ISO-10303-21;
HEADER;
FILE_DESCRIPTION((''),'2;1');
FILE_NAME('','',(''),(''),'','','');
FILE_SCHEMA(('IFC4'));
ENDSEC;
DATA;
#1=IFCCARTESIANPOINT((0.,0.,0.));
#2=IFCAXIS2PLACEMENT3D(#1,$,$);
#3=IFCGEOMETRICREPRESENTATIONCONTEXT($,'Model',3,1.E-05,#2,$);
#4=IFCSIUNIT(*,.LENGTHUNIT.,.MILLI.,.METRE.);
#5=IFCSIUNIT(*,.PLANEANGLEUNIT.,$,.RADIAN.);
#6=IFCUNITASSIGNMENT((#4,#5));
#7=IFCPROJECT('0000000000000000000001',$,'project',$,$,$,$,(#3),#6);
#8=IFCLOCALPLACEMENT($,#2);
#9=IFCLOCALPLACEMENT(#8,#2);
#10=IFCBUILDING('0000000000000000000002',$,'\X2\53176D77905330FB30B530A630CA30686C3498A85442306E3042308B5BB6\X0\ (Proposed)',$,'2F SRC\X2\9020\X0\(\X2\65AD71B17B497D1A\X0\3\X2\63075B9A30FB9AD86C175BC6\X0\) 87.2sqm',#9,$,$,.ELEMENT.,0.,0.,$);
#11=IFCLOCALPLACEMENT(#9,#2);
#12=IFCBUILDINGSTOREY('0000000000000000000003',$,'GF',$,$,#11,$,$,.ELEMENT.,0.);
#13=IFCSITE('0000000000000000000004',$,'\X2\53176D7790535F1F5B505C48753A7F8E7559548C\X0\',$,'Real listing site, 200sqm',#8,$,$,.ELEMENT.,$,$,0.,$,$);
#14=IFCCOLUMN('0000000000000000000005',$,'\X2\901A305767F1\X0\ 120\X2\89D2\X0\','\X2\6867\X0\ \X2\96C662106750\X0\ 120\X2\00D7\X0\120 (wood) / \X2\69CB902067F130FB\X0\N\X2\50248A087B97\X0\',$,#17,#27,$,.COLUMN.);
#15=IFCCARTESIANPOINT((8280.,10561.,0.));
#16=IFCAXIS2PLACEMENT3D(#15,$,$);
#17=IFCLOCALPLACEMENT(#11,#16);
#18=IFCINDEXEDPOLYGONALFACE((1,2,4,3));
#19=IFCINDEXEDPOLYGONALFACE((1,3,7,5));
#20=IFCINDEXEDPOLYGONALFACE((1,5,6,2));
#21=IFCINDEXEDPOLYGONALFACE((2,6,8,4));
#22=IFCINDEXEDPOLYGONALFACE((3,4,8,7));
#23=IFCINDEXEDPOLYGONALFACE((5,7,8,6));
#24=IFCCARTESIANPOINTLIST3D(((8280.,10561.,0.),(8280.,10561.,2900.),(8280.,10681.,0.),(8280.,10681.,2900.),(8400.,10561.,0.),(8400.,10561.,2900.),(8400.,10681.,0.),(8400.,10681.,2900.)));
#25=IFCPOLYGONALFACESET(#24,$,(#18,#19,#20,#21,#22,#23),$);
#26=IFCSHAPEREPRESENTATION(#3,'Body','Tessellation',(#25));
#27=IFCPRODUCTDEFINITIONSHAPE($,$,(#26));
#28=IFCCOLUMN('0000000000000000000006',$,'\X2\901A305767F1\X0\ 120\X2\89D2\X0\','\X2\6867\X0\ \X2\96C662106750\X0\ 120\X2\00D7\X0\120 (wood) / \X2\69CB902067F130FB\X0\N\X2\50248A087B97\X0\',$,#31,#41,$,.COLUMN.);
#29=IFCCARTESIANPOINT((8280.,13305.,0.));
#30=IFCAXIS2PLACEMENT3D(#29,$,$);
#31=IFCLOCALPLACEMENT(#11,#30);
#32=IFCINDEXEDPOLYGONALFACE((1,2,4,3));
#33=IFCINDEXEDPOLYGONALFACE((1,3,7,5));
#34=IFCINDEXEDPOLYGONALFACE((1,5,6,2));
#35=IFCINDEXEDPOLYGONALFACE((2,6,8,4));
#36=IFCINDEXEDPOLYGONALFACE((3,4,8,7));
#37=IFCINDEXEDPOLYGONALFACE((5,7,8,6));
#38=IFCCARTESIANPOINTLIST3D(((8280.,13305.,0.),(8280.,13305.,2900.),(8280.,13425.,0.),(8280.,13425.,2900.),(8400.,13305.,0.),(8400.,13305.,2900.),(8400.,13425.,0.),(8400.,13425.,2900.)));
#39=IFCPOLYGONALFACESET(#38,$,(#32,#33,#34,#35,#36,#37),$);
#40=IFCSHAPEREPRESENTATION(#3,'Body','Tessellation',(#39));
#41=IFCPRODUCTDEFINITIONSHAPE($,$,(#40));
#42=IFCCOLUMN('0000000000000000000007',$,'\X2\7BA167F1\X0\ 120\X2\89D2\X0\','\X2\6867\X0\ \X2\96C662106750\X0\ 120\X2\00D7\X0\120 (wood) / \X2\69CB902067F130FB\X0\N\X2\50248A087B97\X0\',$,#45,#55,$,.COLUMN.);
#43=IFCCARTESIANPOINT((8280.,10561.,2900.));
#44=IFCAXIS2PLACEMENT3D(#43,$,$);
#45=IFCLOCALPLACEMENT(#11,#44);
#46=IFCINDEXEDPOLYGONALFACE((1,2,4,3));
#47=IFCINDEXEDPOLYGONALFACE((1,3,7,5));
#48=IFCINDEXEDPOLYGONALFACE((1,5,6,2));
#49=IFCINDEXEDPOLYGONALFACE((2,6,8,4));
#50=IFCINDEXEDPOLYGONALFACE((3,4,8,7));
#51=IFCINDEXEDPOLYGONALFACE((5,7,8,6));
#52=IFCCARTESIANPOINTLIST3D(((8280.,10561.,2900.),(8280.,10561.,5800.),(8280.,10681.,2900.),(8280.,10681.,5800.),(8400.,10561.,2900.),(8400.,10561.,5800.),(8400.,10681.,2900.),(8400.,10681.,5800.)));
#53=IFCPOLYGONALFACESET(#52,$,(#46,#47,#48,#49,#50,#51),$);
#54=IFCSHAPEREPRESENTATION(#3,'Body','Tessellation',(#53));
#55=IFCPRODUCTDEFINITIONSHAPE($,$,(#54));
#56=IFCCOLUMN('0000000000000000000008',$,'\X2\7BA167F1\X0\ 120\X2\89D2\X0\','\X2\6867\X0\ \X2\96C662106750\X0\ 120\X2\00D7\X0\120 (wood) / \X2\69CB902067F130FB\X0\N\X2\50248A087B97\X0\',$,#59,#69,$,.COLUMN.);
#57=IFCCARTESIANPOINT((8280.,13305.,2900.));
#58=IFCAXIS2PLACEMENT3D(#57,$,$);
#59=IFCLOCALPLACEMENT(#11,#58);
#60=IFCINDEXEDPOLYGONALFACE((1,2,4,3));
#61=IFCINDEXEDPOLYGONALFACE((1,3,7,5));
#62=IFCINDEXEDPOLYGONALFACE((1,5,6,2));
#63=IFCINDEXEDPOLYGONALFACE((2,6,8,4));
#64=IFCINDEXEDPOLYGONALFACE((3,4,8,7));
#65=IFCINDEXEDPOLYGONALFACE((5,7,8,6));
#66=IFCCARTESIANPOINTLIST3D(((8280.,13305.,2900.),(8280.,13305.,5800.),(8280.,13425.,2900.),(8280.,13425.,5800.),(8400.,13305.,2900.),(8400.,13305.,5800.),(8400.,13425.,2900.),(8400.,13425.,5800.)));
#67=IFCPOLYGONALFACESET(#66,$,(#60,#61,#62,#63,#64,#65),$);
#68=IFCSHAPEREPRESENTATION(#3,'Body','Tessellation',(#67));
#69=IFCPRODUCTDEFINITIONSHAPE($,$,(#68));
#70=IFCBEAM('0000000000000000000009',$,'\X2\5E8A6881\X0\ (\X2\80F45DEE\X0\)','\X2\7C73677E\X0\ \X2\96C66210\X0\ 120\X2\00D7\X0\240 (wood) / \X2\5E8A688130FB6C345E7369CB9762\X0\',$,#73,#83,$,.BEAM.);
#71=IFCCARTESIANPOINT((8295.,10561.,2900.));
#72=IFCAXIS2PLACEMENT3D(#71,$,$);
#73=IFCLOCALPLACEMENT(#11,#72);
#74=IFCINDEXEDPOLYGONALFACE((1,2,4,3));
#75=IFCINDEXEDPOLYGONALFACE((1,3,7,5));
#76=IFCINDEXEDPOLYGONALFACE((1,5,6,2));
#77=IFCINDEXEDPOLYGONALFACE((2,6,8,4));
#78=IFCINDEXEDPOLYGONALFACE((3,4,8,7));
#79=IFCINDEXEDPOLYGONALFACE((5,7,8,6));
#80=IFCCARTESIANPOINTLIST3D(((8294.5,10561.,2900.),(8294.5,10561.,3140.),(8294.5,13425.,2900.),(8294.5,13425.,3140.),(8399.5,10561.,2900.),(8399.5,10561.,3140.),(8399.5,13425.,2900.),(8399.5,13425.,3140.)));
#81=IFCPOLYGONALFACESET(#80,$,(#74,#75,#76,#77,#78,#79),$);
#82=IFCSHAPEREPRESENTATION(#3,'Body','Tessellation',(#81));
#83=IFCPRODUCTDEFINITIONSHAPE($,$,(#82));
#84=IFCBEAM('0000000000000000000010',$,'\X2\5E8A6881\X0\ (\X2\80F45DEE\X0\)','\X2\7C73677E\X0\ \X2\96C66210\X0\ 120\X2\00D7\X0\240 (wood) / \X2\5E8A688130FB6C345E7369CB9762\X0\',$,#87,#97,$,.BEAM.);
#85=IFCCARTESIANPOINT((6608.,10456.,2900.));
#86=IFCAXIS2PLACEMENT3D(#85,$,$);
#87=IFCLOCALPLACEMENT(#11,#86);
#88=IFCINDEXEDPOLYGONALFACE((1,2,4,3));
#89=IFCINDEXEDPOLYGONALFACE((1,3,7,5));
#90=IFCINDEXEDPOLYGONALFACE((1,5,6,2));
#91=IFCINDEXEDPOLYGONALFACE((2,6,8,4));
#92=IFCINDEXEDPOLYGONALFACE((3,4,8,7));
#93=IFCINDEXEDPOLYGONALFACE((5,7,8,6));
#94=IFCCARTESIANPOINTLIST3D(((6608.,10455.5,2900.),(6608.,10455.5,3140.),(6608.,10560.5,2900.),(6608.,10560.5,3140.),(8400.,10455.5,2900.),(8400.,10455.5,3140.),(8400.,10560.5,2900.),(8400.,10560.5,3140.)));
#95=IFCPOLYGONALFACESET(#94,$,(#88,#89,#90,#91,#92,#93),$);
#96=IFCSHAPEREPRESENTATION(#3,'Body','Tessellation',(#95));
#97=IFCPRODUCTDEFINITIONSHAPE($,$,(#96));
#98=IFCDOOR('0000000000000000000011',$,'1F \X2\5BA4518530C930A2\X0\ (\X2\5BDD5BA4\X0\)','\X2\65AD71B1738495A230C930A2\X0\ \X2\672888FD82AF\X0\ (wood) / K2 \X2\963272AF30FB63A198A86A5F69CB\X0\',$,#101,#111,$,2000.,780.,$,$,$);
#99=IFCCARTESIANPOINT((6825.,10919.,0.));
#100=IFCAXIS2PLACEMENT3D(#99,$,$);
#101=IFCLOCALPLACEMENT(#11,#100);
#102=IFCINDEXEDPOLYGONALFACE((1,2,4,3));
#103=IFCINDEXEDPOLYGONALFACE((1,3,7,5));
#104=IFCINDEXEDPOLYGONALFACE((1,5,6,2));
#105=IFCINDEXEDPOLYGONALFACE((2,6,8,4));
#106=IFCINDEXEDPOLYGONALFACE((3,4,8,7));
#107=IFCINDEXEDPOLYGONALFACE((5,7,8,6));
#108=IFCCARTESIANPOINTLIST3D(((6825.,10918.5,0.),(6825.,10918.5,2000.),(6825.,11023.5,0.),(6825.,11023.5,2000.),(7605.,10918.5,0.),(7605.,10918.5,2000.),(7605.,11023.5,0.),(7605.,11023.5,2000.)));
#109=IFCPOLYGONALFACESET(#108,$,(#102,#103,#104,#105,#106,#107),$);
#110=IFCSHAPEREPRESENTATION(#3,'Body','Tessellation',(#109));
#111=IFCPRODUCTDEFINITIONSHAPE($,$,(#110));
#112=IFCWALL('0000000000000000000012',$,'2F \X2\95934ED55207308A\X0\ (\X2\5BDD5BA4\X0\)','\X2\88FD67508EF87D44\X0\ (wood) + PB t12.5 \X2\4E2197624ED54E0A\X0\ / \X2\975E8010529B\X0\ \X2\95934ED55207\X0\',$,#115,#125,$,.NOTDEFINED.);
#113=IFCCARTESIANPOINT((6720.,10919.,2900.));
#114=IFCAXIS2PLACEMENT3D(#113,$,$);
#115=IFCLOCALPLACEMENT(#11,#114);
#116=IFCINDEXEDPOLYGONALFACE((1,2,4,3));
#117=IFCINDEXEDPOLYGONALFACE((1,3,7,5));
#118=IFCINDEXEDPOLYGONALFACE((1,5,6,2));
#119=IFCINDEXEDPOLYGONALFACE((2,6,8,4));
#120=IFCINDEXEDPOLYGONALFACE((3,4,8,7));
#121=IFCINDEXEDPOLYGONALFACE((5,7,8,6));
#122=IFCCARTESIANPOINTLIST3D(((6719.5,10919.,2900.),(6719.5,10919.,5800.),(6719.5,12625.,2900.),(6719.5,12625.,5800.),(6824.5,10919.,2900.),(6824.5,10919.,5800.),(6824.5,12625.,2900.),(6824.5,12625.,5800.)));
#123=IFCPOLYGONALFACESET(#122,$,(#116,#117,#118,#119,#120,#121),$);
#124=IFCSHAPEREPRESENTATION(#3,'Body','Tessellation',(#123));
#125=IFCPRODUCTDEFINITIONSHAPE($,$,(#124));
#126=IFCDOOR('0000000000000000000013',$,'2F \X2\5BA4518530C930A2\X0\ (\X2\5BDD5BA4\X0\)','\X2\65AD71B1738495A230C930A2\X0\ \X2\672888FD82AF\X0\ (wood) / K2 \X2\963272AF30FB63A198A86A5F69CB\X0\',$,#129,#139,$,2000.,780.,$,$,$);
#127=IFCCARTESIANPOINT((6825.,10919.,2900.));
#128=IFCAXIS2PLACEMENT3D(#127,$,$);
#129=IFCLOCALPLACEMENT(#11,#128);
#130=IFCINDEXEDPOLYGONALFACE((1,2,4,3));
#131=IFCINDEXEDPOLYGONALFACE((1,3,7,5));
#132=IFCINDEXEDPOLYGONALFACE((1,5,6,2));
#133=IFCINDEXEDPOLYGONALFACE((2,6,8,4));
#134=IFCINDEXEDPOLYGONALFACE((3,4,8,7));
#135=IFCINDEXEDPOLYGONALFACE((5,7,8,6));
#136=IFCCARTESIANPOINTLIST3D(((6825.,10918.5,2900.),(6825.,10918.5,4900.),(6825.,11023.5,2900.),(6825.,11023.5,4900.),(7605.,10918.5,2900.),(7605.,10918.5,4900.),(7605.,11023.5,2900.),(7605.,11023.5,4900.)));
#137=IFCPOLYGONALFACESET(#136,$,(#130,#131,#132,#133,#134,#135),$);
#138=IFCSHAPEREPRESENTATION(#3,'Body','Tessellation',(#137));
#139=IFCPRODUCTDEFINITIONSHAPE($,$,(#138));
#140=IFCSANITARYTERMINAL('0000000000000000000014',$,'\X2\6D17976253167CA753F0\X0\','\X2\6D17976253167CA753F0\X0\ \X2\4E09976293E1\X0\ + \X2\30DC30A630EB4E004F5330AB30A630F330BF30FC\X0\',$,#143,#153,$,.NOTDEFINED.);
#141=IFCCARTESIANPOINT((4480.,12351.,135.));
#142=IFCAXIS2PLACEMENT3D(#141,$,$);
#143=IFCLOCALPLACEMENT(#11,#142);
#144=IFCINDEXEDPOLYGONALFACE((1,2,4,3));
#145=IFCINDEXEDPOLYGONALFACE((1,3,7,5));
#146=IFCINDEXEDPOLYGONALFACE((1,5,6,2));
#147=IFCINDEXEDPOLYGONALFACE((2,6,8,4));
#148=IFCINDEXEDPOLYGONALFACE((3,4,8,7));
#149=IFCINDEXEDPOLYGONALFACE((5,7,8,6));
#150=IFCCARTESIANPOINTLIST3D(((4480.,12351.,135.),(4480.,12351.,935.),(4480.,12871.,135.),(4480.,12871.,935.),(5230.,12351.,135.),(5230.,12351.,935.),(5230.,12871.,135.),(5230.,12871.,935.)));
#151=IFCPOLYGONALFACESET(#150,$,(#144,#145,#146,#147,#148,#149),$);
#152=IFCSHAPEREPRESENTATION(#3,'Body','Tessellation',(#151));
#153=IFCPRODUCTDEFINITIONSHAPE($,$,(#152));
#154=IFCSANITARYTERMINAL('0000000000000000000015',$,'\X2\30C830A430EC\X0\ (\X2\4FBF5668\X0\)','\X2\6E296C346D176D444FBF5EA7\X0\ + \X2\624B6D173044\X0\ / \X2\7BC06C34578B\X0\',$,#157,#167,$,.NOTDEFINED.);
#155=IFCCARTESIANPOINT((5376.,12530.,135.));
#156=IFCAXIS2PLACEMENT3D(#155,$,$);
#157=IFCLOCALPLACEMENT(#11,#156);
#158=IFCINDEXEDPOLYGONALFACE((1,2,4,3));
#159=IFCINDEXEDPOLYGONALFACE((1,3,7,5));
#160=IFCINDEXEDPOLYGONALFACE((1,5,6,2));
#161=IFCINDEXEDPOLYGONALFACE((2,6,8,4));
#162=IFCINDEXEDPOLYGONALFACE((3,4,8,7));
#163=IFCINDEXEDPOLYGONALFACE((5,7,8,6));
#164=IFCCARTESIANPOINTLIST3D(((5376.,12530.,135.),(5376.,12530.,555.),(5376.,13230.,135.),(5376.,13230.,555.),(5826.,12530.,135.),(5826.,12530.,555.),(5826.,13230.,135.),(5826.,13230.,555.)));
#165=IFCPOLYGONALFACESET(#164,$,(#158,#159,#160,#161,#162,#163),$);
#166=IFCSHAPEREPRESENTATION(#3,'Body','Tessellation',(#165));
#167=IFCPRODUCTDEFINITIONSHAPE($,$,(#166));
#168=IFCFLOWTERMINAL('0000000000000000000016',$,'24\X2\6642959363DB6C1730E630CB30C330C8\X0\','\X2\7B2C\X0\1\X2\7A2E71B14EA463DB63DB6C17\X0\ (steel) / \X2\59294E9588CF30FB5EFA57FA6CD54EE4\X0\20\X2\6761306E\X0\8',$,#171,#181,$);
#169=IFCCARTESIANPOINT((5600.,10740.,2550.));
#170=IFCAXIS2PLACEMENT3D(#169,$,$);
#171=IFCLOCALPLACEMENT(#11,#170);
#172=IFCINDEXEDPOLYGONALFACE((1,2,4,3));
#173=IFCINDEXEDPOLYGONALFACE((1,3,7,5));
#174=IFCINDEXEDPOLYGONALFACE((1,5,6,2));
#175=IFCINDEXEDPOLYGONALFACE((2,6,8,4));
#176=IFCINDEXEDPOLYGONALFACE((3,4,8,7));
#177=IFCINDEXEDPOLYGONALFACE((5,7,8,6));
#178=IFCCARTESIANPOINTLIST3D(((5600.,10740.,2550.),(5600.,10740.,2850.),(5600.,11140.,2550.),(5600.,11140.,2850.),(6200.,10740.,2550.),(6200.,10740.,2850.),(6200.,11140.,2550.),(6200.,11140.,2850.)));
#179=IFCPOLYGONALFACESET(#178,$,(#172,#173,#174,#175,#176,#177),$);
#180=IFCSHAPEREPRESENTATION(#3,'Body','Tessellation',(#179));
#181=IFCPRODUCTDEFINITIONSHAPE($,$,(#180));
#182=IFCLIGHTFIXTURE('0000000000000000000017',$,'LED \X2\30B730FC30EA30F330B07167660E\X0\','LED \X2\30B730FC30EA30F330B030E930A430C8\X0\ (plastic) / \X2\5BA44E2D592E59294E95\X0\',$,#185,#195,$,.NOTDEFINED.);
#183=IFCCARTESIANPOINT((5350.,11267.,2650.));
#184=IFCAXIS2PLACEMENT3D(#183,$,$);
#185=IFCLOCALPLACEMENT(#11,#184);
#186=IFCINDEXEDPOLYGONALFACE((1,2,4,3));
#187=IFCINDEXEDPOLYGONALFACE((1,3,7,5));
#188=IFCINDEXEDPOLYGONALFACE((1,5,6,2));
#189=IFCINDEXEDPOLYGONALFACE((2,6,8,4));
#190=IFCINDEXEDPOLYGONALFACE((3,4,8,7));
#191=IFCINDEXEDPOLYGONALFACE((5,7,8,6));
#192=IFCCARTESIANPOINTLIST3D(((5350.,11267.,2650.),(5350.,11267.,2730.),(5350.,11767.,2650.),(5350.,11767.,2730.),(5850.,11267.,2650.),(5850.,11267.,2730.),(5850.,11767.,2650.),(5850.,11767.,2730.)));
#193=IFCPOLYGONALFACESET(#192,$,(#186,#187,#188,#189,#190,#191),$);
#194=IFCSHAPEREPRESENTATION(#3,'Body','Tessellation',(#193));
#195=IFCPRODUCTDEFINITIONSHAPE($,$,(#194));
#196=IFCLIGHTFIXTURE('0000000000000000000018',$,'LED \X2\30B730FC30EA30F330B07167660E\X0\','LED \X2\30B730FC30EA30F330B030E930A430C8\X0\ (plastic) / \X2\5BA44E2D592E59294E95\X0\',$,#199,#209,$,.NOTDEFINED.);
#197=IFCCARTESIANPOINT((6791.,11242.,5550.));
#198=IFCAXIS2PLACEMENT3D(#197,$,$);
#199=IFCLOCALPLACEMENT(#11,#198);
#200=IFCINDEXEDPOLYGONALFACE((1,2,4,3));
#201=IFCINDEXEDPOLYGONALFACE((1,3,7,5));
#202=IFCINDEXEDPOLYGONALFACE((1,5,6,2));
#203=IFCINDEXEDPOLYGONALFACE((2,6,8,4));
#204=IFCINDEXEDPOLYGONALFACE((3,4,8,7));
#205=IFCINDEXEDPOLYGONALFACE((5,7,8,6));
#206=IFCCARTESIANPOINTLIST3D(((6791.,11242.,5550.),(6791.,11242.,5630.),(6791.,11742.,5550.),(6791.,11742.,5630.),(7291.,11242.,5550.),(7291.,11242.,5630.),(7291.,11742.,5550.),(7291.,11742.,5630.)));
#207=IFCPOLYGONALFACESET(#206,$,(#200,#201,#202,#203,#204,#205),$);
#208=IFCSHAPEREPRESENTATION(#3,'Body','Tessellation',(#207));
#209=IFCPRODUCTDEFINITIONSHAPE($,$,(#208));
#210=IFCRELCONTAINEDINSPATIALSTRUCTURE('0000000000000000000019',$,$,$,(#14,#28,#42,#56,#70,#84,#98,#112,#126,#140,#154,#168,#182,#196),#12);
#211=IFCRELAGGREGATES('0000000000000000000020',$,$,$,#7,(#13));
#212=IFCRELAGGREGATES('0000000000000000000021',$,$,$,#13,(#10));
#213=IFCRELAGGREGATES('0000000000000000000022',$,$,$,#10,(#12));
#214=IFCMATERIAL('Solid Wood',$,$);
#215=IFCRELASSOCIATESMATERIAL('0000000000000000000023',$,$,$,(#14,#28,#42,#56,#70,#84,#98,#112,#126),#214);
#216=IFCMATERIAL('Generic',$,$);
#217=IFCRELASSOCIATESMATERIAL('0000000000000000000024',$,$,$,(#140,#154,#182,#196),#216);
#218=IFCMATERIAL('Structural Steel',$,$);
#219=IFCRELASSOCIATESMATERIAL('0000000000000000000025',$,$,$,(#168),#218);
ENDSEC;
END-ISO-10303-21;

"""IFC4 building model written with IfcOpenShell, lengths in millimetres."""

from ifc_helpers import new_model, si_unit, frame, frame_2d, origin, place, context, project, spatial, rectangle, extrude, material, element, save


model = new_model("IFC4")

# Units and contexts
model_context = context("Model", 3, precision=1e-05, world=origin())
ifc_project = project(units=[si_unit("LENGTHUNIT", "METRE", prefix="MILLI"), si_unit("PLANEANGLEUNIT", "RADIAN")], contexts=[model_context])

# Site, building, storey
site_placement = place(None, origin())
site = spatial("IfcSite", under=ifc_project, at=site_placement, Name="北海道弟子屈町美留和", ObjectType="Real listing site, 200sqm", CompositionType="ELEMENT", RefElevation=0.0)
building_placement = place(site_placement, origin())
building = spatial("IfcBuilding", under=site, at=building_placement, Name="北海道・サウナと水風呂のある家 (Proposed)", ObjectType="2F SRC造(断熱等級3指定・高気密) 87.2sqm", CompositionType="ELEMENT", ElevationOfRefHeight=0.0, ElevationOfTerrain=0.0)
storey_placement = place(building_placement, origin())
storey = spatial("IfcBuildingStorey", under=building, at=storey_placement, Name="GF", CompositionType="ELEMENT", Elevation=0.0)

# Columns
ifc_material_1 = material(Name="Solid Wood")
column_1_placement = place(storey_placement, frame((8280.0, 10561.0, 0.0)))
element("IfcColumn", 1, at=column_1_placement, inside=storey, material=ifc_material_1, Name="通し柱 120角", Description="桧 集成材 120×120 (wood) / 構造柱・N値計算", PredefinedType="COLUMN", context=model_context, shape_type="SweptSolid", body=[
    extrude(rectangle(XDim=120.0, YDim=120.0, at=frame_2d((60.0, 60.0))), frame((8280.0, 10561.0, 0.0)), (0.0, 0.0, 1.0), 2900.0),
])
column_2_placement = place(storey_placement, frame((8280.0, 13305.0, 0.0)))
element("IfcColumn", 2, at=column_2_placement, inside=storey, material=ifc_material_1, Name="通し柱 120角", Description="桧 集成材 120×120 (wood) / 構造柱・N値計算", PredefinedType="COLUMN", context=model_context, shape_type="SweptSolid", body=[
    extrude(rectangle(XDim=120.0, YDim=120.0, at=frame_2d((60.0, 60.0))), frame((8280.0, 13305.0, 0.0)), (0.0, 0.0, 1.0), 2900.0),
])
column_3_placement = place(storey_placement, frame((8280.0, 10561.0, 2900.0)))
element("IfcColumn", 3, at=column_3_placement, inside=storey, material=ifc_material_1, Name="管柱 120角", Description="桧 集成材 120×120 (wood) / 構造柱・N値計算", PredefinedType="COLUMN", context=model_context, shape_type="SweptSolid", body=[
    extrude(rectangle(XDim=120.0, YDim=120.0, at=frame_2d((60.0, 60.0))), frame((8280.0, 10561.0, 2900.0)), (0.0, 0.0, 1.0), 2900.0),
])
column_4_placement = place(storey_placement, frame((8280.0, 13305.0, 2900.0)))
element("IfcColumn", 4, at=column_4_placement, inside=storey, material=ifc_material_1, Name="管柱 120角", Description="桧 集成材 120×120 (wood) / 構造柱・N値計算", PredefinedType="COLUMN", context=model_context, shape_type="SweptSolid", body=[
    extrude(rectangle(XDim=120.0, YDim=120.0, at=frame_2d((60.0, 60.0))), frame((8280.0, 13305.0, 2900.0)), (0.0, 0.0, 1.0), 2900.0),
])

# Beams
beam_1_placement = place(storey_placement, frame((8295.0, 10561.0, 2900.0)))
element("IfcBeam", 5, at=beam_1_placement, inside=storey, material=ifc_material_1, Name="床梁 (胴差)", Description="米松 集成 120×240 (wood) / 床梁・水平構面", PredefinedType="BEAM", context=model_context, shape_type="SweptSolid", body=[
    extrude(rectangle(XDim=105.0, YDim=2864.0, at=frame_2d((52.0, 1432.0))), frame((8295.0, 10561.0, 2900.0)), (0.0, 0.0, 1.0), 240.0),
])
beam_2_placement = place(storey_placement, frame((6608.0, 10456.0, 2900.0)))
element("IfcBeam", 6, at=beam_2_placement, inside=storey, material=ifc_material_1, Name="床梁 (胴差)", Description="米松 集成 120×240 (wood) / 床梁・水平構面", PredefinedType="BEAM", context=model_context, shape_type="SweptSolid", body=[
    extrude(rectangle(XDim=1792.0, YDim=105.0, at=frame_2d((896.0, 52.0))), frame((6608.0, 10456.0, 2900.0)), (0.0, 0.0, 1.0), 240.0),
])

# Door
door_1_placement = place(storey_placement, frame((6825.0, 10919.0, 0.0)))
element("IfcDoor", 7, at=door_1_placement, inside=storey, material=ifc_material_1, Name="1F 室内ドア (寝室)", Description="断熱玄関ドア 木製芯 (wood) / K2 防犯・採風機構", OverallHeight=2000.0, OverallWidth=780.0, context=model_context, shape_type="SweptSolid", body=[
    extrude(rectangle(XDim=780.0, YDim=105.0, at=frame_2d((390.0, 52.0))), frame((6825.0, 10919.0, 0.0)), (0.0, 0.0, 1.0), 2000.0),
])

# Wall
wall_1_placement = place(storey_placement, frame((6720.0, 10919.0, 2900.0)))
element("IfcWall", 8, at=wall_1_placement, inside=storey, material=ifc_material_1, Name="2F 間仕切り (寝室)", Description="製材軸組 (wood) + PB t12.5 両面仕上 / 非耐力 間仕切", PredefinedType="NOTDEFINED", context=model_context, shape_type="SweptSolid", body=[
    extrude(rectangle(XDim=105.0, YDim=1706.0, at=frame_2d((52.0, 853.0))), frame((6720.0, 10919.0, 2900.0)), (0.0, 0.0, 1.0), 2900.0),
])

# Door
door_2_placement = place(storey_placement, frame((6825.0, 10919.0, 2900.0)))
element("IfcDoor", 9, at=door_2_placement, inside=storey, material=ifc_material_1, Name="2F 室内ドア (寝室)", Description="断熱玄関ドア 木製芯 (wood) / K2 防犯・採風機構", OverallHeight=2000.0, OverallWidth=780.0, context=model_context, shape_type="SweptSolid", body=[
    extrude(rectangle(XDim=780.0, YDim=105.0, at=frame_2d((390.0, 52.0))), frame((6825.0, 10919.0, 2900.0)), (0.0, 0.0, 1.0), 2000.0),
])

# Sanitary terminals
ifc_material_2 = material(Name="Generic")
sanitary_terminal_1_placement = place(storey_placement, frame((4480.0, 12351.0, 135.0)))
element("IfcSanitaryTerminal", 10, at=sanitary_terminal_1_placement, inside=storey, material=ifc_material_2, Name="洗面化粧台", Description="洗面化粧台 三面鏡 + ボウル一体カウンター", PredefinedType="NOTDEFINED", context=model_context, shape_type="SweptSolid", body=[
    extrude(rectangle(XDim=750.0, YDim=520.0, at=frame_2d((375.0, 260.0))), frame((4480.0, 12351.0, 135.0)), (0.0, 0.0, 1.0), 800.0),
])
sanitary_terminal_2_placement = place(storey_placement, frame((5376.0, 12530.0, 135.0)))
element("IfcSanitaryTerminal", 11, at=sanitary_terminal_2_placement, inside=storey, material=ifc_material_2, Name="トイレ (便器)", Description="温水洗浄便座 + 手洗い / 節水型", PredefinedType="NOTDEFINED", context=model_context, shape_type="SweptSolid", body=[
    extrude(rectangle(XDim=450.0, YDim=700.0, at=frame_2d((225.0, 350.0))), frame((5376.0, 12530.0, 135.0)), (0.0, 0.0, 1.0), 420.0),
])

# Flow terminal
ifc_material_3 = material(Name="Structural Steel")
flow_terminal_placement = place(storey_placement, frame((5600.0, 10740.0, 2550.0)))
element("IfcFlowTerminal", 12, at=flow_terminal_placement, inside=storey, material=ifc_material_3, Name="24時間換気ユニット", Description="第1種熱交換換気 (steel) / 天井裏・建基法令20条の8", context=model_context, shape_type="SweptSolid", body=[
    extrude(rectangle(XDim=600.0, YDim=400.0, at=frame_2d((300.0, 200.0))), frame((5600.0, 10740.0, 2550.0)), (0.0, 0.0, 1.0), 300.0),
])

# Light fixtures
light_fixture_1_placement = place(storey_placement, frame((5350.0, 11267.0, 2650.0)))
element("IfcLightFixture", 13, at=light_fixture_1_placement, inside=storey, material=ifc_material_2, Name="LED シーリング照明", Description="LED シーリングライト (plastic) / 室中央天井", PredefinedType="NOTDEFINED", context=model_context, shape_type="SweptSolid", body=[
    extrude(rectangle(XDim=500.0, YDim=500.0, at=frame_2d((250.0, 250.0))), frame((5350.0, 11267.0, 2650.0)), (0.0, 0.0, 1.0), 80.0),
])
light_fixture_2_placement = place(storey_placement, frame((6791.0, 11242.0, 5550.0)))
element("IfcLightFixture", 14, at=light_fixture_2_placement, inside=storey, material=ifc_material_2, Name="LED シーリング照明", Description="LED シーリングライト (plastic) / 室中央天井", PredefinedType="NOTDEFINED", context=model_context, shape_type="SweptSolid", body=[
    extrude(rectangle(XDim=500.0, YDim=500.0, at=frame_2d((250.0, 250.0))), frame((6791.0, 11242.0, 5550.0)), (0.0, 0.0, 1.0), 80.0),
])

save(model, "model.ifc")
